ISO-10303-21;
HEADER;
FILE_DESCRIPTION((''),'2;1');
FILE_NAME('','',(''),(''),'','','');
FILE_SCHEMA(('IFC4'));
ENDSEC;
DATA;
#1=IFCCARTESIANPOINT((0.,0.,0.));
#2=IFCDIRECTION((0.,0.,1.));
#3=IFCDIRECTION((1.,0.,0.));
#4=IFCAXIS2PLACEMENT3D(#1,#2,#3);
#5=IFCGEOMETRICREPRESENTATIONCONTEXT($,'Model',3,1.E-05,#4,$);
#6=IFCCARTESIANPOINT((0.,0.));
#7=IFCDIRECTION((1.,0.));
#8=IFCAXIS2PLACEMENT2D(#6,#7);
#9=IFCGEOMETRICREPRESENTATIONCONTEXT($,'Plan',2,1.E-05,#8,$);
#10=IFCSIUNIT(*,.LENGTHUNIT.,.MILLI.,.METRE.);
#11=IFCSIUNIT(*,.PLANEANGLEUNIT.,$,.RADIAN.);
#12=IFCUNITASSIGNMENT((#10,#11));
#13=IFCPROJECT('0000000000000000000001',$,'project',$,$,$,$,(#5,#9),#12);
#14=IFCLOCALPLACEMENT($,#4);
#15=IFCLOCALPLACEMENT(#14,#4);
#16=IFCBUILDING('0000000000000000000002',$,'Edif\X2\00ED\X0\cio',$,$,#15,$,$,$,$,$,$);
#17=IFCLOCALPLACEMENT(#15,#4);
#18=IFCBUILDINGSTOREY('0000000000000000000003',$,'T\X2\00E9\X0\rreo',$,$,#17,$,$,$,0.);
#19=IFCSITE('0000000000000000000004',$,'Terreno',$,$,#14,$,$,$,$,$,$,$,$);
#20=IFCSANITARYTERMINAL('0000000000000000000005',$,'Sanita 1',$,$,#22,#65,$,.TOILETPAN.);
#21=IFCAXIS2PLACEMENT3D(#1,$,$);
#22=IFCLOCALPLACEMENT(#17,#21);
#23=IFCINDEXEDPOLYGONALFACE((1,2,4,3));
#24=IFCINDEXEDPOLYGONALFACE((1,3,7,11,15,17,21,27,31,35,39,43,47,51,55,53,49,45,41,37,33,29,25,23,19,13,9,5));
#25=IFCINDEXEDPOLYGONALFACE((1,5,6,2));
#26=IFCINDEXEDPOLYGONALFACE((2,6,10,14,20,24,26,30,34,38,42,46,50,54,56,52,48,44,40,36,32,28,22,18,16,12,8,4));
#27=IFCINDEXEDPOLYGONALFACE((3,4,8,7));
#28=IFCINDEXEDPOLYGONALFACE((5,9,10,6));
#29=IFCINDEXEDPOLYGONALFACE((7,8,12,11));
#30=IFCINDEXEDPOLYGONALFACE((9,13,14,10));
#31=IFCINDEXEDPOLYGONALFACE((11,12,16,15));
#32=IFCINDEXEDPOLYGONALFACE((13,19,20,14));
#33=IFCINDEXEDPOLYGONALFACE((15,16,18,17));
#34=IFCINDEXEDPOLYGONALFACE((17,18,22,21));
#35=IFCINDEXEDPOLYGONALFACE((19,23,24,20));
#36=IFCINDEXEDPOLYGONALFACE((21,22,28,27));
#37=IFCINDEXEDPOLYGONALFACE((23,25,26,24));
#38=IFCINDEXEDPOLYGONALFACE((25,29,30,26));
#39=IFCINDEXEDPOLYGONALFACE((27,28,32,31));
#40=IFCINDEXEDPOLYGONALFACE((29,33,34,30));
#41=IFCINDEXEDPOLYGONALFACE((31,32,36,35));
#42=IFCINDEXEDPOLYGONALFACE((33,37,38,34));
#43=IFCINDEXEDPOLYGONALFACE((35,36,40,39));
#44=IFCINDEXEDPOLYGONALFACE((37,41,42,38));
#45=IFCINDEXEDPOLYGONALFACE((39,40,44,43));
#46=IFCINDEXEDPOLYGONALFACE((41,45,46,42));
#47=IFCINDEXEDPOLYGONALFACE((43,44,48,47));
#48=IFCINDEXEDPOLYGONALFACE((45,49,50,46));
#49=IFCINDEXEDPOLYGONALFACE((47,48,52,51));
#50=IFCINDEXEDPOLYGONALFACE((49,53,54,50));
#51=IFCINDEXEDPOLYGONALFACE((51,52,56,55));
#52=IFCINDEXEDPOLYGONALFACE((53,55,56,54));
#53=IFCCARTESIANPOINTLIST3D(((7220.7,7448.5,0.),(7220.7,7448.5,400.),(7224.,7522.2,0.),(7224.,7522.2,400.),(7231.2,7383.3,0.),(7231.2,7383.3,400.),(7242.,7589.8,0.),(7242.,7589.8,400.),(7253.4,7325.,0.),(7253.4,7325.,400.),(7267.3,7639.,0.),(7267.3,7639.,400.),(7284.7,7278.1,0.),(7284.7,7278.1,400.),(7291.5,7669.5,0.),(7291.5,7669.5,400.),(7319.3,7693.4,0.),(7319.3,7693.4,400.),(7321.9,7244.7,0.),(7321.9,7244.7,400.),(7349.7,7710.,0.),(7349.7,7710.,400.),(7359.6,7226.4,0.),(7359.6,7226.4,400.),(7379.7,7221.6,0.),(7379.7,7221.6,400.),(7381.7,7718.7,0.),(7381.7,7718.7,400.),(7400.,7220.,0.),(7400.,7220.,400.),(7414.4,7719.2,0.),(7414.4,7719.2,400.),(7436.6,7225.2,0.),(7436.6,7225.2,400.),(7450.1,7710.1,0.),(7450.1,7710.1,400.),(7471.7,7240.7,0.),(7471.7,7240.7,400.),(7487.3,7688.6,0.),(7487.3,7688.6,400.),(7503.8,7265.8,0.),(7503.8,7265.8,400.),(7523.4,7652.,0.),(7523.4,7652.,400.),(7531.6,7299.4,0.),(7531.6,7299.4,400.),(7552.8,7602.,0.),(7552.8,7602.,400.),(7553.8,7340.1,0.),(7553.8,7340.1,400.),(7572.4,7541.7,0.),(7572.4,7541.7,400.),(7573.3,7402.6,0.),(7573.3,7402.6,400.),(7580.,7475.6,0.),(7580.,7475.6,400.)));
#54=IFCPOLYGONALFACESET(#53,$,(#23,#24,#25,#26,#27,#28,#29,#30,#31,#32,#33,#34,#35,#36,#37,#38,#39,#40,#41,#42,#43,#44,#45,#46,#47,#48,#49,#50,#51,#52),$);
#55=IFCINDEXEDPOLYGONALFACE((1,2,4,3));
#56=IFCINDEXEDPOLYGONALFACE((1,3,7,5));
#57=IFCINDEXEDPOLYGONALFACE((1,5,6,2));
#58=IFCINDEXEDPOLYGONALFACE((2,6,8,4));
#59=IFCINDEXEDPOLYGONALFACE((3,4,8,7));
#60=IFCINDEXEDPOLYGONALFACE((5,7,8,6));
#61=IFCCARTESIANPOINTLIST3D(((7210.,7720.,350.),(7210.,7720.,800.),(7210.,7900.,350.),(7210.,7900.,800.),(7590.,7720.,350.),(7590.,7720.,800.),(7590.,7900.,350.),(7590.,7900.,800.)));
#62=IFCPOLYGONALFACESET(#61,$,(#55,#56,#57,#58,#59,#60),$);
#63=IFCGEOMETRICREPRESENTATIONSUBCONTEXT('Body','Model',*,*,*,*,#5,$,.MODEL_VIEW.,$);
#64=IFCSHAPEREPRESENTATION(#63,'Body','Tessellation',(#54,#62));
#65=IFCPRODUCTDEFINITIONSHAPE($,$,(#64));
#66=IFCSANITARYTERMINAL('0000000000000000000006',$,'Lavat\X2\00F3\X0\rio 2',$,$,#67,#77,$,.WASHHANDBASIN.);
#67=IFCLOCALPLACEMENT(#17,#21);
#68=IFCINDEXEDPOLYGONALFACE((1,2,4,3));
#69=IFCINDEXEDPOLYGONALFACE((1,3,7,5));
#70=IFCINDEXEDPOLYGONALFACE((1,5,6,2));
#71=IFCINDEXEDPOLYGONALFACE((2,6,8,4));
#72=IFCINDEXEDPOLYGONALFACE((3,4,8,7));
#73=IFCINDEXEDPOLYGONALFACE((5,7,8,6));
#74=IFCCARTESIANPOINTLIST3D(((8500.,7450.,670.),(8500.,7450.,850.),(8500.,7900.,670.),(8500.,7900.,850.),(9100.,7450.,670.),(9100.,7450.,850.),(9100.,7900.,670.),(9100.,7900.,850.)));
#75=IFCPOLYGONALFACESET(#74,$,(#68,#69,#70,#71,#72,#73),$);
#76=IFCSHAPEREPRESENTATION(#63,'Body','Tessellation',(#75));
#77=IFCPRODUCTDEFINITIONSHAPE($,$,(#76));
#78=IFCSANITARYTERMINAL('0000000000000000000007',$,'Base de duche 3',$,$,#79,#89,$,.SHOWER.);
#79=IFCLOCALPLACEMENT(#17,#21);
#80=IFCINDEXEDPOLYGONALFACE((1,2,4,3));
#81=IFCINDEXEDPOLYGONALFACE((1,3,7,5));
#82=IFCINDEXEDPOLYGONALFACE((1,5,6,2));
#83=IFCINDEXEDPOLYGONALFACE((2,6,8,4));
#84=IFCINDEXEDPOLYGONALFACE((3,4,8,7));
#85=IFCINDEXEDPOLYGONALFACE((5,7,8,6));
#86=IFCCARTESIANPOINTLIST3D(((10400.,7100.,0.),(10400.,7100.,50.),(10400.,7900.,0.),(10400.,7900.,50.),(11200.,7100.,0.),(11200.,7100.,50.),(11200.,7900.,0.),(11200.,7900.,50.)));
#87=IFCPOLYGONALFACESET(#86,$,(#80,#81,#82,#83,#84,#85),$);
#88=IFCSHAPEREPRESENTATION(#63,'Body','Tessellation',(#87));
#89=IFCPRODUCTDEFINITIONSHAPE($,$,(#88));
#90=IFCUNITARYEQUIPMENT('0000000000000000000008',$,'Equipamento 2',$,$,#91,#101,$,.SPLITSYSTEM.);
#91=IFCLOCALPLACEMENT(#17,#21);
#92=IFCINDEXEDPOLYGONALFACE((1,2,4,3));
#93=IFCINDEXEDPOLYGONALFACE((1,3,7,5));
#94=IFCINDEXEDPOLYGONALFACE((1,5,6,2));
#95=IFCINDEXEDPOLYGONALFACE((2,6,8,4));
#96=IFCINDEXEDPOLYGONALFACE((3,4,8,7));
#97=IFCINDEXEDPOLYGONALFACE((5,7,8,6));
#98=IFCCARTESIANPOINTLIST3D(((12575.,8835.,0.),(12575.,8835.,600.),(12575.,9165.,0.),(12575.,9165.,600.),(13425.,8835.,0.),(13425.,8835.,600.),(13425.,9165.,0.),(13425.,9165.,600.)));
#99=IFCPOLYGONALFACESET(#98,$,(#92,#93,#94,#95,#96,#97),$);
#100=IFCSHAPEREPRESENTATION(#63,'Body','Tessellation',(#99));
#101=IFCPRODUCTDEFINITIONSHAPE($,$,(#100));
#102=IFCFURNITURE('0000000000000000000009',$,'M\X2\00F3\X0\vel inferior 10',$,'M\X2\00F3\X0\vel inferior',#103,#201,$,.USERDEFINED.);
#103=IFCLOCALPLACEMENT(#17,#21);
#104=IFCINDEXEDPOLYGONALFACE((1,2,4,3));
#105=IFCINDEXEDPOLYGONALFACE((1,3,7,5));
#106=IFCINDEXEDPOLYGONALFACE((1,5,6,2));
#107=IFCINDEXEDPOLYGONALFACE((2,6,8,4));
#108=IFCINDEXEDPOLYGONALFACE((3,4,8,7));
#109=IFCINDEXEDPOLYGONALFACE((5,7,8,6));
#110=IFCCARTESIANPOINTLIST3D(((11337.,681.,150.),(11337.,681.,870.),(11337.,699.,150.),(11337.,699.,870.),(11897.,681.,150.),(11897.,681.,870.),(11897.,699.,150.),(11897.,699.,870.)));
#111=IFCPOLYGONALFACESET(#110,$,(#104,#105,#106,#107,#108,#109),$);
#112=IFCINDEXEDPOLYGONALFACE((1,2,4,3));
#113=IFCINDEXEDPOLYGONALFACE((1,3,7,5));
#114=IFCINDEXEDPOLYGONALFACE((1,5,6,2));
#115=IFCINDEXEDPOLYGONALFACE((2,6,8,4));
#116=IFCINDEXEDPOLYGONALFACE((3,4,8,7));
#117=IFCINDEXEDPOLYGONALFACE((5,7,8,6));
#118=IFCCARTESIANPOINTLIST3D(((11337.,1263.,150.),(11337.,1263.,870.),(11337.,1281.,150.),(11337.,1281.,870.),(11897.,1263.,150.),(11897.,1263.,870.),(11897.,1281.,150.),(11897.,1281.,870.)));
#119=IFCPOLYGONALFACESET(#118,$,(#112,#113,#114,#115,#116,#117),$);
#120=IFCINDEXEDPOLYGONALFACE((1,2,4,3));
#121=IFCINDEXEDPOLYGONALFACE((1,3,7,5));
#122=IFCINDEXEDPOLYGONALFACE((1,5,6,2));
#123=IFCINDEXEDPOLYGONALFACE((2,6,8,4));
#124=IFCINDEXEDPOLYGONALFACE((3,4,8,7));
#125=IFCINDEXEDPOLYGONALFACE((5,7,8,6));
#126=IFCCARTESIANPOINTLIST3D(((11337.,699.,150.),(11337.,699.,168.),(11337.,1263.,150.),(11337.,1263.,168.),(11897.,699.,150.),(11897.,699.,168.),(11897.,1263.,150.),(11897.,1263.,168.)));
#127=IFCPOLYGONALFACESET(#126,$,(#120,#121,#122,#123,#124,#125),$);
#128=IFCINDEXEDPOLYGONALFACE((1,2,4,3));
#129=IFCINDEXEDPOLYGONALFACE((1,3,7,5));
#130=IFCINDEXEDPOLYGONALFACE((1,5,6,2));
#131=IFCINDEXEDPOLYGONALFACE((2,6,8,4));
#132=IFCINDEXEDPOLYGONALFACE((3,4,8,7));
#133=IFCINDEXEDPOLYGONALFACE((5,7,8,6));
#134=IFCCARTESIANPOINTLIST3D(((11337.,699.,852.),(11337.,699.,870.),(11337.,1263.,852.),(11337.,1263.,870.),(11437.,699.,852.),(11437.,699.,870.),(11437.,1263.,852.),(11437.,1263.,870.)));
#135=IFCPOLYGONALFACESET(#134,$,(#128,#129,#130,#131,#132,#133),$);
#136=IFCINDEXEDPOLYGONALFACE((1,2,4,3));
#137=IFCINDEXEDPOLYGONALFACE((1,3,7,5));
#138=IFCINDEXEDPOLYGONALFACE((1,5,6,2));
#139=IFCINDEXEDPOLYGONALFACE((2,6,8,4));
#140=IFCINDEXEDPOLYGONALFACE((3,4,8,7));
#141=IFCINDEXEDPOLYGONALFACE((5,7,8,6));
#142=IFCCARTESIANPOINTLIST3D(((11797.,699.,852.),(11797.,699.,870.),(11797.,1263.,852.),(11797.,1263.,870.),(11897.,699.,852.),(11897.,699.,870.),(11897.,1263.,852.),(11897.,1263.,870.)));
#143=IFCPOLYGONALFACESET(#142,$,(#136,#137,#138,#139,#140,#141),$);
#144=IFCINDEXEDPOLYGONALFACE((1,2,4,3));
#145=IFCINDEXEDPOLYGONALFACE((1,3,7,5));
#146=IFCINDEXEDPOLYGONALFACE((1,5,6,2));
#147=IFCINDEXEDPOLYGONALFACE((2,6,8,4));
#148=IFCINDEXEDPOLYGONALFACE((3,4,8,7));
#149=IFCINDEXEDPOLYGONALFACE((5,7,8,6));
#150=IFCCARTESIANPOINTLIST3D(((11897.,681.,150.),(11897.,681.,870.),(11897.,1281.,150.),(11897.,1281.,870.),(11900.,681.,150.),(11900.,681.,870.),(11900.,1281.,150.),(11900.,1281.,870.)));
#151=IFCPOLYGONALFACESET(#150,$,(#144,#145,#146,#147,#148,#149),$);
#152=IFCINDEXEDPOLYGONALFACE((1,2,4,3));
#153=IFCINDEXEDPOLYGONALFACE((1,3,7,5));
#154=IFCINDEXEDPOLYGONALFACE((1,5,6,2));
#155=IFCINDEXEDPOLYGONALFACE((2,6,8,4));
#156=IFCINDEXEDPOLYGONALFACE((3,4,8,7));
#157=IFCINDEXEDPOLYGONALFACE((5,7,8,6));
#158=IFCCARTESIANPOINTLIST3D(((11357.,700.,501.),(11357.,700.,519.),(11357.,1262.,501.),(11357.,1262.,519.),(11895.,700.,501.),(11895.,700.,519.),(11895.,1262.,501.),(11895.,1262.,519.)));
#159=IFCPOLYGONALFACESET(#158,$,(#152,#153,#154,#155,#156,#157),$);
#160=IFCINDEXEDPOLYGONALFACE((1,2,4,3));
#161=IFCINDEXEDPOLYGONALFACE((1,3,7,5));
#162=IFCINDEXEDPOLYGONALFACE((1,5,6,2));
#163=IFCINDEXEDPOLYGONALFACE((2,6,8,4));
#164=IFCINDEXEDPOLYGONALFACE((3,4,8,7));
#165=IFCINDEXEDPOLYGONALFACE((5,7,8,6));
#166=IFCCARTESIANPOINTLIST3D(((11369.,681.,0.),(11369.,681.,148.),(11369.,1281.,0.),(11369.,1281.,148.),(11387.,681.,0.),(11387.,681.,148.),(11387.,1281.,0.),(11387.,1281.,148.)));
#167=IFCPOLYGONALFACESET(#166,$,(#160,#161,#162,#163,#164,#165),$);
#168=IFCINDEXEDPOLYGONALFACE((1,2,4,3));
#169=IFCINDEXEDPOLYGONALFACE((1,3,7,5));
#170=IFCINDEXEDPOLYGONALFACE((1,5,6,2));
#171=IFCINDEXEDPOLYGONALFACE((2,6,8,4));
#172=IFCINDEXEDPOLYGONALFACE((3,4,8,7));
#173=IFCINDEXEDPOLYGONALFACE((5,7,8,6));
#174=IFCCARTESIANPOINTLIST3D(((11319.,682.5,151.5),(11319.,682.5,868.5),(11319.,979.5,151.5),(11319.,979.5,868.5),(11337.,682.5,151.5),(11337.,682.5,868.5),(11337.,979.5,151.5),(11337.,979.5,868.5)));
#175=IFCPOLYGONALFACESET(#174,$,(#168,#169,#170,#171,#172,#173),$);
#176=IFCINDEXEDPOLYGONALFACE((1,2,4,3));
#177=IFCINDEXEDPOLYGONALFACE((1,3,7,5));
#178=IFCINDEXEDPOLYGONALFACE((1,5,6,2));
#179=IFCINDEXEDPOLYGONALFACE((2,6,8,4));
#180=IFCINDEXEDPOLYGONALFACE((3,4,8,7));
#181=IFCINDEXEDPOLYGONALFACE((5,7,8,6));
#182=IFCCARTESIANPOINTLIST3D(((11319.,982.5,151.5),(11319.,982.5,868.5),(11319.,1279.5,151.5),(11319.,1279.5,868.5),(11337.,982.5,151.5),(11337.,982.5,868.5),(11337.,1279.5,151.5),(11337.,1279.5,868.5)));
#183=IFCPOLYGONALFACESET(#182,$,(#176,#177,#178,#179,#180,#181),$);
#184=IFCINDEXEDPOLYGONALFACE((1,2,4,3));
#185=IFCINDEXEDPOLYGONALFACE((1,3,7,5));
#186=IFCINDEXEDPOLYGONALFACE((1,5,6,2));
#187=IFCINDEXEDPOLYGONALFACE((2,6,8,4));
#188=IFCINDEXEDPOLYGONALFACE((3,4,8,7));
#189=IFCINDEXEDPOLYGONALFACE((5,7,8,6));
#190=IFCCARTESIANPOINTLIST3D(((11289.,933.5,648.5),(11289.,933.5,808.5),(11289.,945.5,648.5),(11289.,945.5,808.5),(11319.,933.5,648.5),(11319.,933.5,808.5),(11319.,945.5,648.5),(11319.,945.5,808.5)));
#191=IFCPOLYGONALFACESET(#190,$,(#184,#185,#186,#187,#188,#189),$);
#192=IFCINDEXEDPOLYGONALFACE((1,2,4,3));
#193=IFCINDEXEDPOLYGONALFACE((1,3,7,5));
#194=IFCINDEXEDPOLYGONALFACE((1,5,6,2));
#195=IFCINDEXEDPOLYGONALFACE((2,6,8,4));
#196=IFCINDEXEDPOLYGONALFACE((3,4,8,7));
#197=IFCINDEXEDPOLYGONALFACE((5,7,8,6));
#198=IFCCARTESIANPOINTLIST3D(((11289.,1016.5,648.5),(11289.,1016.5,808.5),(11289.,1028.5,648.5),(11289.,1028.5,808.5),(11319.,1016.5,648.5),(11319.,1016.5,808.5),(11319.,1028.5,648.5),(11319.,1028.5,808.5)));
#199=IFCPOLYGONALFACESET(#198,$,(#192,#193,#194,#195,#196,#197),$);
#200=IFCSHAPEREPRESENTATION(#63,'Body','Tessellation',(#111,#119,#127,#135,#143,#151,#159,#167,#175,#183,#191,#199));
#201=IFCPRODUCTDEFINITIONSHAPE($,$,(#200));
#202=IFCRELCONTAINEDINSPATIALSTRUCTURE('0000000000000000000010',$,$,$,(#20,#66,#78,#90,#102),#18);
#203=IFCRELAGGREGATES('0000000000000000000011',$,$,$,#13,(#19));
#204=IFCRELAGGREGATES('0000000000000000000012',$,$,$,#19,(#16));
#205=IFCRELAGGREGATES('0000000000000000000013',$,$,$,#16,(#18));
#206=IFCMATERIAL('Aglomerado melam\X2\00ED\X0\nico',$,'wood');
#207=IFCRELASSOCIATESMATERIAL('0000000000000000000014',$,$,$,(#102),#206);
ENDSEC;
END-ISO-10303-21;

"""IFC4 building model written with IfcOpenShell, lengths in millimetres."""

from ifc_helpers import new_model, si_unit, frame, frame_2d, origin, origin_with_axes, origin_2d, origin_2d_with_axis, place, context, subcontext, project, spatial, rectangle, ellipse, extrude, material, element, save


model = new_model("IFC4")

# Units and contexts
model_context = context("Model", 3, precision=1e-05, world=origin_with_axes())
plan_context = context("Plan", 2, precision=1e-05, world=origin_2d_with_axis())
body_context = subcontext(model_context, "Body", "Model", "MODEL_VIEW")
ifc_project = project(units=[si_unit("LENGTHUNIT", "METRE", prefix="MILLI"), si_unit("PLANEANGLEUNIT", "RADIAN")], contexts=[model_context, plan_context])

# Site, building, storey
site_placement = place(None, origin_with_axes())
site = spatial("IfcSite", under=ifc_project, at=site_placement, Name="Terreno")
building_placement = place(site_placement, origin_with_axes())
building = spatial("IfcBuilding", under=site, at=building_placement, Name="Edifício")
storey_placement = place(building_placement, origin_with_axes())
storey = spatial("IfcBuildingStorey", under=building, at=storey_placement, Name="Térreo", Elevation=0.0)

# Sanitary terminals
sanitary_terminal_1_placement = place(storey_placement, frame((7400.0, 7900.0, 0.0), z_axis=(0.0, 0.0, 1.0), x_axis=(-1.0, 0.0, 0.0)))
element("IfcSanitaryTerminal", 1, at=sanitary_terminal_1_placement, inside=storey, Name="Sanita 1", PredefinedType="TOILETPAN", context=body_context, shape_type="SweptSolid", body=[
    extrude(ellipse(SemiAxis1=180.0, SemiAxis2=250.0, at=frame_2d((0.0, 430.0))), origin(), (0.0, 0.0, 1.0), 400.0),
    extrude(rectangle(XDim=380.0, YDim=180.0, at=frame_2d((0.0, 90.0))), frame((0.0, 0.0, 350.0)), (0.0, 0.0, 1.0), 450.0),
])
sanitary_terminal_2_placement = place(storey_placement, frame((8800.0, 7900.0, 0.0), z_axis=(0.0, 0.0, 1.0), x_axis=(-1.0, 0.0, 0.0)))
element("IfcSanitaryTerminal", 2, at=sanitary_terminal_2_placement, inside=storey, Name="Lavatório 2", PredefinedType="WASHHANDBASIN", context=body_context, shape_type="SweptSolid", body=[
    extrude(rectangle(XDim=600.0, YDim=450.0, at=frame_2d((0.0, 225.0))), frame((0.0, 0.0, 670.0)), (0.0, 0.0, 1.0), 180.0),
])
sanitary_terminal_3_placement = place(storey_placement, frame((10800.0, 7900.0, 0.0), z_axis=(0.0, 0.0, 1.0), x_axis=(-1.0, 0.0, 0.0)))
element("IfcSanitaryTerminal", 3, at=sanitary_terminal_3_placement, inside=storey, Name="Base de duche 3", PredefinedType="SHOWER", context=body_context, shape_type="SweptSolid", body=[
    extrude(rectangle(XDim=800.0, YDim=800.0, at=frame_2d((0.0, 400.0))), origin(), (0.0, 0.0, 1.0), 50.0),
])

# Unitary equipment
unitary_equipment_placement = place(storey_placement, frame((13000.0, 9000.0, 0.0), z_axis=(0.0, 0.0, 1.0), x_axis=(1.0, 0.0, 0.0)))
element("IfcUnitaryEquipment", 4, at=unitary_equipment_placement, inside=storey, Name="Equipamento 2", PredefinedType="SPLITSYSTEM", context=body_context, shape_type="SweptSolid", body=[
    extrude(rectangle(XDim=850.0, YDim=330.0, at=origin_2d()), origin(), (0.0, 0.0, 1.0), 600.0),
])

# Furniture
ifc_material_1 = material(Name="Aglomerado melamínico", Category="wood")
furniture_1_placement = place(storey_placement, frame((11900.0, 681.0, 0.0), z_axis=(0.0, 0.0, 1.0), x_axis=(0.0, 1.0, 0.0)))
element("IfcFurniture", 5, at=furniture_1_placement, inside=storey, material=ifc_material_1, Name="Móvel inferior 10", ObjectType="Móvel inferior", PredefinedType="USERDEFINED", context=body_context, shape_type="SweptSolid", body=[
    extrude(rectangle(XDim=18.0, YDim=560.0, at=frame_2d((9.0, 283.0))), frame((0.0, 0.0, 150.0)), (0.0, 0.0, 1.0), 720.0),
    extrude(rectangle(XDim=18.0, YDim=560.0, at=frame_2d((591.0, 283.0))), frame((0.0, 0.0, 150.0)), (0.0, 0.0, 1.0), 720.0),
    extrude(rectangle(XDim=564.0, YDim=560.0, at=frame_2d((300.0, 283.0))), frame((0.0, 0.0, 150.0)), (0.0, 0.0, 1.0), 18.0),
    extrude(rectangle(XDim=564.0, YDim=100.0, at=frame_2d((300.0, 513.0))), frame((0.0, 0.0, 852.0)), (0.0, 0.0, 1.0), 18.0),
    extrude(rectangle(XDim=564.0, YDim=100.0, at=frame_2d((300.0, 53.0))), frame((0.0, 0.0, 852.0)), (0.0, 0.0, 1.0), 18.0),
    extrude(rectangle(XDim=600.0, YDim=3.0, at=frame_2d((300.0, 1.5))), frame((0.0, 0.0, 150.0)), (0.0, 0.0, 1.0), 720.0),
    extrude(rectangle(XDim=562.0, YDim=538.0, at=frame_2d((300.0, 274.0))), frame((0.0, 0.0, 501.0)), (0.0, 0.0, 1.0), 18.0),
    extrude(rectangle(XDim=600.0, YDim=18.0, at=frame_2d((300.0, 522.0))), origin(), (0.0, 0.0, 1.0), 148.0),
    extrude(rectangle(XDim=297.0, YDim=18.0, at=frame_2d((150.0, 572.0))), frame((0.0, 0.0, 151.5)), (0.0, 0.0, 1.0), 717.0),
    extrude(rectangle(XDim=297.0, YDim=18.0, at=frame_2d((450.0, 572.0))), frame((0.0, 0.0, 151.5)), (0.0, 0.0, 1.0), 717.0),
    extrude(rectangle(XDim=12.0, YDim=30.0, at=frame_2d((258.5, 596.0))), frame((0.0, 0.0, 648.5)), (0.0, 0.0, 1.0), 160.0),
    extrude(rectangle(XDim=12.0, YDim=30.0, at=frame_2d((341.5, 596.0))), frame((0.0, 0.0, 648.5)), (0.0, 0.0, 1.0), 160.0),
])

save(model, "model.ifc")
